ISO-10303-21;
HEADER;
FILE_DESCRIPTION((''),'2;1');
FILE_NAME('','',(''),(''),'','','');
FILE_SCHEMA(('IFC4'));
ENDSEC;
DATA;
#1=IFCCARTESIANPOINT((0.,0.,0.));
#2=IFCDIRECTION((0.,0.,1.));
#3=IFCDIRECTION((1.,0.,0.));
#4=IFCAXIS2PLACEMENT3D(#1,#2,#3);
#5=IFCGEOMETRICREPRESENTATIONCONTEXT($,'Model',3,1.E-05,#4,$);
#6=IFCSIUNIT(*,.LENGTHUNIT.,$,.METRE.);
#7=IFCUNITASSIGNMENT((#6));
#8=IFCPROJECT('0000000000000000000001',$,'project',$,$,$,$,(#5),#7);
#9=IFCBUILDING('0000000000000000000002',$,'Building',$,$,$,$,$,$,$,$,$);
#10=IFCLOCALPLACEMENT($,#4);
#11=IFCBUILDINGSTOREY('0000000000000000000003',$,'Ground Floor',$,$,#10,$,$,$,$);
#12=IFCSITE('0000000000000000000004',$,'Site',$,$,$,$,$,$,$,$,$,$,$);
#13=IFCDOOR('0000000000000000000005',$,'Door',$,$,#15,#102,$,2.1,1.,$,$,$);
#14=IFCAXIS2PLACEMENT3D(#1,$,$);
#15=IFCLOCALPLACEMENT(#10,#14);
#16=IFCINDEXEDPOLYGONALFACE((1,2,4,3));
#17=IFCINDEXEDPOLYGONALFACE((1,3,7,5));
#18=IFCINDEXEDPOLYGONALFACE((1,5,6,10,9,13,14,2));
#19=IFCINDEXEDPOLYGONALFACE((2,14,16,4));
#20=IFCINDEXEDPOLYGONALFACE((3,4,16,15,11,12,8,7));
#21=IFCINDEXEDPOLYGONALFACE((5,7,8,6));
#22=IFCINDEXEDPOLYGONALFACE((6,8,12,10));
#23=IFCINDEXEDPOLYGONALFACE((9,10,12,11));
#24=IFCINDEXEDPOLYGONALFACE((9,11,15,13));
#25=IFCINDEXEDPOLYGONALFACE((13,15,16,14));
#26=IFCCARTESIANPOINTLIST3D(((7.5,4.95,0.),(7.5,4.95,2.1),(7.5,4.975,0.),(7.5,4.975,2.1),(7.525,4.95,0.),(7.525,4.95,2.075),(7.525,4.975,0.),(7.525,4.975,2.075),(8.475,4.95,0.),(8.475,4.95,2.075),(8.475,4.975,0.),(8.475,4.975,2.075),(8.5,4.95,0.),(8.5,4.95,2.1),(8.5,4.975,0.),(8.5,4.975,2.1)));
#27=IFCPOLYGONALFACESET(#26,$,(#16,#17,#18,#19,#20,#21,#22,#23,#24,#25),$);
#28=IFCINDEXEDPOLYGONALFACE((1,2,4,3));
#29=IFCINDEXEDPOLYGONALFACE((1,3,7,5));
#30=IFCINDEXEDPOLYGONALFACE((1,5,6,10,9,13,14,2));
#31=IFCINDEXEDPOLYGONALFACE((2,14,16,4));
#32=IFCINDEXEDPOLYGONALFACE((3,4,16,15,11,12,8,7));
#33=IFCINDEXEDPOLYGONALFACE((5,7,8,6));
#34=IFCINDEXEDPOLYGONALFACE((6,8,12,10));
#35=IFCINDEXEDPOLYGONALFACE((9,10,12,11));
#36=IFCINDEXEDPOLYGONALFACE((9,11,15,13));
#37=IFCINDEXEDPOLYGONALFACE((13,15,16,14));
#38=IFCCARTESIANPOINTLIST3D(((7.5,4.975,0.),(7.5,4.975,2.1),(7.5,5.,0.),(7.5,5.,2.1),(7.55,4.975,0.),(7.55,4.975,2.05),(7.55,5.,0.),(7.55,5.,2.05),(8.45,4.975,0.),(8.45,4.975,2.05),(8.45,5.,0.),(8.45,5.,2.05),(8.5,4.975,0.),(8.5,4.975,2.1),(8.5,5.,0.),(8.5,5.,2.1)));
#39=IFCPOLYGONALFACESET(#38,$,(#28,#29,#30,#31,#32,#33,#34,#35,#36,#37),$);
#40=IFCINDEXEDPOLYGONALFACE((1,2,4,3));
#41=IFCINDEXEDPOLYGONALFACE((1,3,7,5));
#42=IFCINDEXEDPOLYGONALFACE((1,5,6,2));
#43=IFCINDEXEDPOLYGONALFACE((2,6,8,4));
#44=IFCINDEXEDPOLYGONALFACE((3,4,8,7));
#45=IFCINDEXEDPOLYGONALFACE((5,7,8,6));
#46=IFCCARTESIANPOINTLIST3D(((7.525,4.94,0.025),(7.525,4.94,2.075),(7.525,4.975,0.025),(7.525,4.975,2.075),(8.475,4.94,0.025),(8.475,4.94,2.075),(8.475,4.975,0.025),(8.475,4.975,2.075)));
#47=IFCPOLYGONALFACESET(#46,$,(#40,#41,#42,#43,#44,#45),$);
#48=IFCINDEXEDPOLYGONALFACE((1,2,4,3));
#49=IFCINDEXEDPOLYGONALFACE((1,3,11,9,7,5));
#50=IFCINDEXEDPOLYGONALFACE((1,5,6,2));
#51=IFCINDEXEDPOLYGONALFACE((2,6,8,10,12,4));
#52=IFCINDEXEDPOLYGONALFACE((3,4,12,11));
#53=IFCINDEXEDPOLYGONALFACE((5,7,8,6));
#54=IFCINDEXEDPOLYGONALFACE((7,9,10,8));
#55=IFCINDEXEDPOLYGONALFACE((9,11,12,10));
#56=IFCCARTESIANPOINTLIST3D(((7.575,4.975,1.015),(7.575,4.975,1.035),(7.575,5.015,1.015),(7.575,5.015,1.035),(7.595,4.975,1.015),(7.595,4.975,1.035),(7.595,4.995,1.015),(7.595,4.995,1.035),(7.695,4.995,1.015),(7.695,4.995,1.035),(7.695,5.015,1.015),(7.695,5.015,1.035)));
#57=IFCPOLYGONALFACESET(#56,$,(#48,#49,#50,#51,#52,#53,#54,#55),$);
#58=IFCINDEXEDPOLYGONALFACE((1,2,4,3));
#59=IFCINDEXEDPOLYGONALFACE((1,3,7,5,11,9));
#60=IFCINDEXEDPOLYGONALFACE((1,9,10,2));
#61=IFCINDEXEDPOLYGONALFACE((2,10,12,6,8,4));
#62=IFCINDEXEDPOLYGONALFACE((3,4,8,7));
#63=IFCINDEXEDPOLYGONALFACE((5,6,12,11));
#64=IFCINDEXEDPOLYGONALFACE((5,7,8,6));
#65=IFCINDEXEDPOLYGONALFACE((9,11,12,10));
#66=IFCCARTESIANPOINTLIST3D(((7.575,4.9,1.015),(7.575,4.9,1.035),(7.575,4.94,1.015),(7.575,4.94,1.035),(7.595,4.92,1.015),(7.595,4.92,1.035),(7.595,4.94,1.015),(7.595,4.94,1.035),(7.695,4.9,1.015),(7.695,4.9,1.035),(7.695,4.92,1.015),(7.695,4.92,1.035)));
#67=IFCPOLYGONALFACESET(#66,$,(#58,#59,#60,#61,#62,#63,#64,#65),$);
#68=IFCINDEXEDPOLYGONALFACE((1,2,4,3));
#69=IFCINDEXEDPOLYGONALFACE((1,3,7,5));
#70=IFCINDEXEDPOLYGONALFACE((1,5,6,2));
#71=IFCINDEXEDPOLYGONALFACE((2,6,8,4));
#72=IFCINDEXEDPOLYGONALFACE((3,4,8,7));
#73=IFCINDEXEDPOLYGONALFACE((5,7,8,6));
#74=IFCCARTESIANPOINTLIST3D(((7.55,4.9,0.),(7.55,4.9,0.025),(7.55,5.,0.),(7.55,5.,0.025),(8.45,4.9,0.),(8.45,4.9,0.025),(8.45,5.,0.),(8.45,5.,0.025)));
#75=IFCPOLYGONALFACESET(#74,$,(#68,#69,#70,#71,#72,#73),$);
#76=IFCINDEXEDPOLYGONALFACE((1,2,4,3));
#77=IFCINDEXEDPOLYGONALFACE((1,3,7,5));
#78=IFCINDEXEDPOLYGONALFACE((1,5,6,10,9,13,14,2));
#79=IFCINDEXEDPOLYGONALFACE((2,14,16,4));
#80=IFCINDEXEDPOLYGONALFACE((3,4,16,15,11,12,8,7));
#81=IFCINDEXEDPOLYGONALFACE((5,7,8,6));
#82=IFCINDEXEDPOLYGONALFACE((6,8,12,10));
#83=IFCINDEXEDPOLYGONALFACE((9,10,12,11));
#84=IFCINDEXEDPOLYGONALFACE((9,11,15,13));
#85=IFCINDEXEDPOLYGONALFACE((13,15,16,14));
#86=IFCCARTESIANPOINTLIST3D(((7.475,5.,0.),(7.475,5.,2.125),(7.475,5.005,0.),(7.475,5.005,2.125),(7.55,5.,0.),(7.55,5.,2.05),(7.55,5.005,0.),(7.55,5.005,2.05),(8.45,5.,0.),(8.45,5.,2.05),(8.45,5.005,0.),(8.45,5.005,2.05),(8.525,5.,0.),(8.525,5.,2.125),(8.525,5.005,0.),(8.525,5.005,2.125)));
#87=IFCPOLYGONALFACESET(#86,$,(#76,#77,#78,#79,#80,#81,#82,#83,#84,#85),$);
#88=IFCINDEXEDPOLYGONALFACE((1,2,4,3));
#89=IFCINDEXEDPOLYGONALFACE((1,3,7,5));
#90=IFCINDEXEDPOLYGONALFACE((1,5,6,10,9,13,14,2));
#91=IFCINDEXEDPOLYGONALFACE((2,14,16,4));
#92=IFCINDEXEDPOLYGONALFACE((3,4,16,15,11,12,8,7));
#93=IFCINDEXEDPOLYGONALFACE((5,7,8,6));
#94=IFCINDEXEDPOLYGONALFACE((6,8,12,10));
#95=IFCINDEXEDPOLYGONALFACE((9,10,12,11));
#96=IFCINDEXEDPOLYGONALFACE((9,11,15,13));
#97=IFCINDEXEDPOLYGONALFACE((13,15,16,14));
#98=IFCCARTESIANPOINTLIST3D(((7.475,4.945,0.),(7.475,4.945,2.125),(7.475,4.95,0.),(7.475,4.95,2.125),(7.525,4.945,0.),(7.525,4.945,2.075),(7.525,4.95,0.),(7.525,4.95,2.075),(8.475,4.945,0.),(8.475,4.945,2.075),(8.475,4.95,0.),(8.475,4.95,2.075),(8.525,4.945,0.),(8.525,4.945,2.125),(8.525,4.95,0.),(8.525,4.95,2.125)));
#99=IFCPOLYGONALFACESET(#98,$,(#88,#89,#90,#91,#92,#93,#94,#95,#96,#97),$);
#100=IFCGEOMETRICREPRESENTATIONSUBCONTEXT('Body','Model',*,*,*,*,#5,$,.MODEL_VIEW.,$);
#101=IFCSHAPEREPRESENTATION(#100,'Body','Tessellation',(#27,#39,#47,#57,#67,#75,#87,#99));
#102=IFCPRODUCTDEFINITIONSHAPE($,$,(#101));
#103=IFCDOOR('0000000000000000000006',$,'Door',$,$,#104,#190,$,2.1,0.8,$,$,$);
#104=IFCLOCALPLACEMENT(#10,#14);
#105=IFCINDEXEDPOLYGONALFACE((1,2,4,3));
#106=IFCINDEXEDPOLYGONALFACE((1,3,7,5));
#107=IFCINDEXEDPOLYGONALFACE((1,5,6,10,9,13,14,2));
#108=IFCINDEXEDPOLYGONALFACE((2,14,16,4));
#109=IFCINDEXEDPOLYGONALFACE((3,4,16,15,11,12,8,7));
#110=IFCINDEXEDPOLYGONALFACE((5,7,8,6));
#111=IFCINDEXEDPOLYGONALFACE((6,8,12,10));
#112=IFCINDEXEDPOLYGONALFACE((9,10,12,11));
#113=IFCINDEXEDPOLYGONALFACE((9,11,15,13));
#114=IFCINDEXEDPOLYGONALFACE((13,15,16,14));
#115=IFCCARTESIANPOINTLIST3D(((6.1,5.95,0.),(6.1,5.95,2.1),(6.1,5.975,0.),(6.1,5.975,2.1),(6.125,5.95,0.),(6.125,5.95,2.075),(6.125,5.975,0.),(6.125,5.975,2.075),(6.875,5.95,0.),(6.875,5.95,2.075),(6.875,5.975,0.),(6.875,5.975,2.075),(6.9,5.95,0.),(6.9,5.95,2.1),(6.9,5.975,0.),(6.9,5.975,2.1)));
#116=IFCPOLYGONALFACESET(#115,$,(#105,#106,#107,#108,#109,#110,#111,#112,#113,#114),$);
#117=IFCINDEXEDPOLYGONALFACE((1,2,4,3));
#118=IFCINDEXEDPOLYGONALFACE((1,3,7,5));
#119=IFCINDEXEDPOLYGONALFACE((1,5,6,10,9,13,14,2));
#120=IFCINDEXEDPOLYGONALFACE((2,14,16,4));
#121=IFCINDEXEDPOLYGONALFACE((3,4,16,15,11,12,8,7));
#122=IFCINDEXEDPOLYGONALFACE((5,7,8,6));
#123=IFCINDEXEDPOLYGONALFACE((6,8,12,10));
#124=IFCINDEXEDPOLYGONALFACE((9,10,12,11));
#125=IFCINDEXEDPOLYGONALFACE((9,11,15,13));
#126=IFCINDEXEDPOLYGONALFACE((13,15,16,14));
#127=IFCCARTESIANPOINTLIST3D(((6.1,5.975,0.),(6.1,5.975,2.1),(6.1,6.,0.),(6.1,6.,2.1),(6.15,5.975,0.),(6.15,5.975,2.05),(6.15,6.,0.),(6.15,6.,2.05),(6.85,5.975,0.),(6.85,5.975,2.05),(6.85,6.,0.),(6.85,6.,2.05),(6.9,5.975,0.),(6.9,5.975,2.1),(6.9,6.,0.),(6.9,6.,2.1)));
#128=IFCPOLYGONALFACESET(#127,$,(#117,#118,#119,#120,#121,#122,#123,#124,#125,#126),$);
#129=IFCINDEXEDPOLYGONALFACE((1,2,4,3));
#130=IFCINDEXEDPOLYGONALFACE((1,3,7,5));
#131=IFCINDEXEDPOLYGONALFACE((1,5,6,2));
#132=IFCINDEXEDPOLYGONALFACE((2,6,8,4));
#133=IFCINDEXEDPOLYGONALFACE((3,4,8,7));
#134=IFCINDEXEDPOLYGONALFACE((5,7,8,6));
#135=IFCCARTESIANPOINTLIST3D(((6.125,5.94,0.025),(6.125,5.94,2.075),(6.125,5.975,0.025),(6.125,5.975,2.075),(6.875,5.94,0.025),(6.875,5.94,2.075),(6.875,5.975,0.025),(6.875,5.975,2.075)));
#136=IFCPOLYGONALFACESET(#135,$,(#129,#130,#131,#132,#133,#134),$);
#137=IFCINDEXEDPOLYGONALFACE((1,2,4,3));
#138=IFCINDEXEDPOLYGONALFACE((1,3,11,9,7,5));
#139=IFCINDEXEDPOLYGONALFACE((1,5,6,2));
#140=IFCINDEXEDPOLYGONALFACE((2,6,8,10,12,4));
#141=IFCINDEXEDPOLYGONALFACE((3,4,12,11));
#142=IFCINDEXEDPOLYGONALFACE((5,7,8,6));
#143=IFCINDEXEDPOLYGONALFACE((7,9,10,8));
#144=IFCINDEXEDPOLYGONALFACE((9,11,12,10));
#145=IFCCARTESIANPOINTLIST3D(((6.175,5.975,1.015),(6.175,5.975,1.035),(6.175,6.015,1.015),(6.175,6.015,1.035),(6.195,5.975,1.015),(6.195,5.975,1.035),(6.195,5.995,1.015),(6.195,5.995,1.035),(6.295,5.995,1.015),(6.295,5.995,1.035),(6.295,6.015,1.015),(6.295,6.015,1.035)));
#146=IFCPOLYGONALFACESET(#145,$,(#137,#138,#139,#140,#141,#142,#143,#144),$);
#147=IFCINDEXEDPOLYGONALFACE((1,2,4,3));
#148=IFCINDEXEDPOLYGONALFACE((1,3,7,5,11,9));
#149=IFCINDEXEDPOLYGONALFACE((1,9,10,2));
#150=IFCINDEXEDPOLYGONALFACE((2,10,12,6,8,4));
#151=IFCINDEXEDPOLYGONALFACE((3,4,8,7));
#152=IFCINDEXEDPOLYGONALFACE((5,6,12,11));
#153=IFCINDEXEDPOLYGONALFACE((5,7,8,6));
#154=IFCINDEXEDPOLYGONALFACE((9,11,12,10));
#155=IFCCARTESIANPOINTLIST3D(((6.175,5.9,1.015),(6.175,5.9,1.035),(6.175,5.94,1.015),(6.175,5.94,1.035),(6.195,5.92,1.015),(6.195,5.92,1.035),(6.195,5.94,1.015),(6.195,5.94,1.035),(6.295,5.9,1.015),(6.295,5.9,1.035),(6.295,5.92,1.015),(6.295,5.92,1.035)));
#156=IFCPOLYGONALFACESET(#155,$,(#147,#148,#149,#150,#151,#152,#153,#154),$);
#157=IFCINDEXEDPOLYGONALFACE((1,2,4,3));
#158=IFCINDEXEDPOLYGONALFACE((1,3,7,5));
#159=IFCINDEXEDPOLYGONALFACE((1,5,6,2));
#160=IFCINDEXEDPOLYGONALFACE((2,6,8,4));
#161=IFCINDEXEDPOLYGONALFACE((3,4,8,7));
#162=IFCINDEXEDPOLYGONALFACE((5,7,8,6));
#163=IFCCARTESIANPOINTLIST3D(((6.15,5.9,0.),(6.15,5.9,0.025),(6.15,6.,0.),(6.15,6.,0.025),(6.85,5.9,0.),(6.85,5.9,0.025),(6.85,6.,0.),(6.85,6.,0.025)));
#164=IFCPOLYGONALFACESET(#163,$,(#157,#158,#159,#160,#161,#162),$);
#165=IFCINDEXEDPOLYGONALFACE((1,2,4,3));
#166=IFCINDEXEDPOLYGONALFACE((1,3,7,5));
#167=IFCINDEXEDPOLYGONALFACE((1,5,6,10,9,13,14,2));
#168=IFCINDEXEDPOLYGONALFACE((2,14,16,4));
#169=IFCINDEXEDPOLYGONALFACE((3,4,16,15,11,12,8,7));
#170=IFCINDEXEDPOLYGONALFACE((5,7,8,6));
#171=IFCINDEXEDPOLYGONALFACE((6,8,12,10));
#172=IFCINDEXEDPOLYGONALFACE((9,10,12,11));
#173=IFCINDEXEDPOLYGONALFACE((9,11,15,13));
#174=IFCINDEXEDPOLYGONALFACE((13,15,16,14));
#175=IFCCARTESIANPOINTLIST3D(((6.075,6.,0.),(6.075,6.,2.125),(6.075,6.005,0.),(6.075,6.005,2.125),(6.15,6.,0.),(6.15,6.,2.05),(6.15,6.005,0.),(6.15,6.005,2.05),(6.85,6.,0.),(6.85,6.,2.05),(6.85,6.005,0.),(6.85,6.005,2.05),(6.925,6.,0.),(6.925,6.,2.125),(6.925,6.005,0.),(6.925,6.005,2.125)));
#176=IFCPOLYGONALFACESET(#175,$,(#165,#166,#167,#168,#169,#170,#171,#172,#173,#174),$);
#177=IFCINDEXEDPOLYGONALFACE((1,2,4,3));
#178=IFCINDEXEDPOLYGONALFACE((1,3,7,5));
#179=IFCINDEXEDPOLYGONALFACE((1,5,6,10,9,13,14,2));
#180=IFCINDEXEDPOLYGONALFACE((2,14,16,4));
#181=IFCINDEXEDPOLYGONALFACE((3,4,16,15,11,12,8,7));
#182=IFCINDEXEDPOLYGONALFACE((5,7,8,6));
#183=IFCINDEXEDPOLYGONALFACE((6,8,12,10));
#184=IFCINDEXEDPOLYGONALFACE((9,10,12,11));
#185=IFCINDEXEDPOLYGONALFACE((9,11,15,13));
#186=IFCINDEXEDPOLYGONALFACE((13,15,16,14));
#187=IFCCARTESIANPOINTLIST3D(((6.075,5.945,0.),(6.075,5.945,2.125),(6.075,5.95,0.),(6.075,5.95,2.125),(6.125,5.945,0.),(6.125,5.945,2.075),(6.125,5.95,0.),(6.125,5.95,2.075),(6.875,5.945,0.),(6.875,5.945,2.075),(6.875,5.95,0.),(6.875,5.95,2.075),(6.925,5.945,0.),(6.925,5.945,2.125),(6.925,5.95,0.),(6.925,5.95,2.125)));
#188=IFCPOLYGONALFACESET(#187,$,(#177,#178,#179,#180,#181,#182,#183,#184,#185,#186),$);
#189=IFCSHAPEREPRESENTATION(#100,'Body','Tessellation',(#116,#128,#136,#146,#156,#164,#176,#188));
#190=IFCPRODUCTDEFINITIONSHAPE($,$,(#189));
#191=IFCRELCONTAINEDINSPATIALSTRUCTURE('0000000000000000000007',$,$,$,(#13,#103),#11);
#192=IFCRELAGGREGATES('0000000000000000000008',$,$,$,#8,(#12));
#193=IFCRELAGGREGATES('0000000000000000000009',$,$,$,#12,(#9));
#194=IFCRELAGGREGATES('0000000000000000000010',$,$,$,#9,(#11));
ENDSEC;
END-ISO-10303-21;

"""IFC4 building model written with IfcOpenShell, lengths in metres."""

from ifc_helpers import new_model, si_unit, frame, origin_with_axes, place, context, subcontext, project, spatial, line, indexed_curve, outline, extrude, element, save


model = new_model("IFC4")

# Units and contexts
model_context = context("Model", 3, precision=1e-05, world=origin_with_axes())
body_context = subcontext(model_context, "Body", "Model", "MODEL_VIEW")
ifc_project = project(units=[si_unit("LENGTHUNIT", "METRE")], contexts=[model_context])

# Site, building, storey
site = spatial("IfcSite", under=ifc_project, Name="Site")
building = spatial("IfcBuilding", under=site, Name="Building")
storey_placement = place(None, origin_with_axes())
storey = spatial("IfcBuildingStorey", under=building, at=storey_placement, Name="Ground Floor")

# Doors
door_1_placement = place(storey_placement, frame((8.5, 5.0, 0.0), z_axis=(0.0, 0.0, 1.0), x_axis=(-1.0, 0.0, 0.0)))
element("IfcDoor", 1, at=door_1_placement, inside=storey, Name="Door", OverallHeight=2.1, OverallWidth=1.0, context=body_context, shape_type="SweptSolid", body=[
    extrude(outline(indexed_curve([(0.0, 0.0), (0.0, 2.1), (1.0, 2.1), (1.0, 0.0), (0.975, 0.0), (0.975, 2.075), (0.025, 2.075), (0.025, 0.0)], segments=[line(1, 2, 3, 4, 5, 6, 7, 8, 1)])), frame((0.0, 0.025, 0.0), z_axis=(0.0, -1.0, 0.0), x_axis=(1.0, 0.0, 0.0)), (0.0, 0.0, -1.0), 0.025),
    extrude(outline(indexed_curve([(0.0, 0.0), (0.0, 2.1), (1.0, 2.1), (1.0, 0.0), (0.95, 0.0), (0.95, 2.05), (0.05, 2.05), (0.05, 0.0)], segments=[line(1, 2, 3, 4, 5, 6, 7, 8, 1)])), frame((0.0, 0.0, 0.0), z_axis=(0.0, -1.0, 0.0), x_axis=(1.0, 0.0, 0.0)), (0.0, 0.0, -1.0), 0.025),
    extrude(outline(indexed_curve([(0.0, 0.0), (0.95, 0.0), (0.95, 0.035), (0.0, 0.035)], segments=[line(1, 2, 3, 4, 1)])), frame((0.025, 0.025, 0.025), z_axis=(0.0, 0.0, 1.0), x_axis=(1.0, 0.0, 0.0)), (0.0, 0.0, 1.0), 2.05),
    extrude(outline(indexed_curve([(0.0, 0.0), (0.0, -0.04), (-0.12, -0.04), (-0.12, -0.02), (-0.02, -0.02), (-0.02, 0.0)], segments=[line(1, 2, 3, 4, 5, 6, 1)])), frame((0.925, 0.025, 1.015), z_axis=(0.0, 0.0, 1.0), x_axis=(1.0, 0.0, 0.0)), (0.0, 0.0, 1.0), 0.02),
    extrude(outline(indexed_curve([(0.0, 0.0), (0.0, 0.04), (-0.12, 0.04), (-0.12, 0.02), (-0.02, 0.02), (-0.02, 0.0)], segments=[line(1, 2, 3, 4, 5, 6, 1)])), frame((0.925, 0.06, 1.015), z_axis=(0.0, 0.0, 1.0), x_axis=(1.0, 0.0, 0.0)), (0.0, 0.0, 1.0), 0.02),
    extrude(outline(indexed_curve([(0.0, 0.0), (0.9, 0.0), (0.9, 0.1), (0.0, 0.1)], segments=[line(1, 2, 3, 4, 1)])), frame((0.05, 0.0, 0.0), z_axis=(0.0, 0.0, 1.0), x_axis=(1.0, 0.0, 0.0)), (0.0, 0.0, 1.0), 0.025),
    extrude(outline(indexed_curve([(0.0, 0.0), (0.0, 2.125), (1.05, 2.125), (1.05, 0.0), (0.975, 0.0), (0.975, 2.05), (0.075, 2.05), (0.075, 0.0)], segments=[line(1, 2, 3, 4, 5, 6, 7, 8, 1)])), frame((-0.025, -0.005, 0.0), z_axis=(0.0, -1.0, 0.0), x_axis=(1.0, 0.0, 0.0)), (0.0, 0.0, -1.0), 0.005),
    extrude(outline(indexed_curve([(0.0, 0.0), (0.0, 2.125), (1.05, 2.125), (1.05, 0.0), (1.0, 0.0), (1.0, 2.075), (0.05, 2.075), (0.05, 0.0)], segments=[line(1, 2, 3, 4, 5, 6, 7, 8, 1)])), frame((-0.025, 0.05, 0.0), z_axis=(0.0, -1.0, 0.0), x_axis=(1.0, 0.0, 0.0)), (0.0, 0.0, -1.0), 0.005),
])
door_2_placement = place(storey_placement, frame((6.9, 6.0, 0.0), z_axis=(0.0, 0.0, 1.0), x_axis=(-1.0, 0.0, 0.0)))
element("IfcDoor", 2, at=door_2_placement, inside=storey, Name="Door", OverallHeight=2.1, OverallWidth=0.8, context=body_context, shape_type="SweptSolid", body=[
    extrude(outline(indexed_curve([(0.0, 0.0), (0.0, 2.1), (0.8, 2.1), (0.8, 0.0), (0.775, 0.0), (0.775, 2.075), (0.025, 2.075), (0.025, 0.0)], segments=[line(1, 2, 3, 4, 5, 6, 7, 8, 1)])), frame((0.0, 0.025, 0.0), z_axis=(0.0, -1.0, 0.0), x_axis=(1.0, 0.0, 0.0)), (0.0, 0.0, -1.0), 0.025),
    extrude(outline(indexed_curve([(0.0, 0.0), (0.0, 2.1), (0.8, 2.1), (0.8, 0.0), (0.75, 0.0), (0.75, 2.05), (0.05, 2.05), (0.05, 0.0)], segments=[line(1, 2, 3, 4, 5, 6, 7, 8, 1)])), frame((0.0, 0.0, 0.0), z_axis=(0.0, -1.0, 0.0), x_axis=(1.0, 0.0, 0.0)), (0.0, 0.0, -1.0), 0.025),
    extrude(outline(indexed_curve([(0.0, 0.0), (0.75, 0.0), (0.75, 0.035), (0.0, 0.035)], segments=[line(1, 2, 3, 4, 1)])), frame((0.025, 0.025, 0.025), z_axis=(0.0, 0.0, 1.0), x_axis=(1.0, 0.0, 0.0)), (0.0, 0.0, 1.0), 2.05),
    extrude(outline(indexed_curve([(0.0, 0.0), (0.0, -0.04), (-0.12, -0.04), (-0.12, -0.02), (-0.02, -0.02), (-0.02, 0.0)], segments=[line(1, 2, 3, 4, 5, 6, 1)])), frame((0.725, 0.025, 1.015), z_axis=(0.0, 0.0, 1.0), x_axis=(1.0, 0.0, 0.0)), (0.0, 0.0, 1.0), 0.02),
    extrude(outline(indexed_curve([(0.0, 0.0), (0.0, 0.04), (-0.12, 0.04), (-0.12, 0.02), (-0.02, 0.02), (-0.02, 0.0)], segments=[line(1, 2, 3, 4, 5, 6, 1)])), frame((0.725, 0.06, 1.015), z_axis=(0.0, 0.0, 1.0), x_axis=(1.0, 0.0, 0.0)), (0.0, 0.0, 1.0), 0.02),
    extrude(outline(indexed_curve([(0.0, 0.0), (0.7, 0.0), (0.7, 0.1), (0.0, 0.1)], segments=[line(1, 2, 3, 4, 1)])), frame((0.05, 0.0, 0.0), z_axis=(0.0, 0.0, 1.0), x_axis=(1.0, 0.0, 0.0)), (0.0, 0.0, 1.0), 0.025),
    extrude(outline(indexed_curve([(0.0, 0.0), (0.0, 2.125), (0.85, 2.125), (0.85, 0.0), (0.775, 0.0), (0.775, 2.05), (0.075, 2.05), (0.075, 0.0)], segments=[line(1, 2, 3, 4, 5, 6, 7, 8, 1)])), frame((-0.025, -0.005, 0.0), z_axis=(0.0, -1.0, 0.0), x_axis=(1.0, 0.0, 0.0)), (0.0, 0.0, -1.0), 0.005),
    extrude(outline(indexed_curve([(0.0, 0.0), (0.0, 2.125), (0.85, 2.125), (0.85, 0.0), (0.8, 0.0), (0.8, 2.075), (0.05, 2.075), (0.05, 0.0)], segments=[line(1, 2, 3, 4, 5, 6, 7, 8, 1)])), frame((-0.025, 0.05, 0.0), z_axis=(0.0, -1.0, 0.0), x_axis=(1.0, 0.0, 0.0)), (0.0, 0.0, -1.0), 0.005),
])

save(model, "model.ifc")
